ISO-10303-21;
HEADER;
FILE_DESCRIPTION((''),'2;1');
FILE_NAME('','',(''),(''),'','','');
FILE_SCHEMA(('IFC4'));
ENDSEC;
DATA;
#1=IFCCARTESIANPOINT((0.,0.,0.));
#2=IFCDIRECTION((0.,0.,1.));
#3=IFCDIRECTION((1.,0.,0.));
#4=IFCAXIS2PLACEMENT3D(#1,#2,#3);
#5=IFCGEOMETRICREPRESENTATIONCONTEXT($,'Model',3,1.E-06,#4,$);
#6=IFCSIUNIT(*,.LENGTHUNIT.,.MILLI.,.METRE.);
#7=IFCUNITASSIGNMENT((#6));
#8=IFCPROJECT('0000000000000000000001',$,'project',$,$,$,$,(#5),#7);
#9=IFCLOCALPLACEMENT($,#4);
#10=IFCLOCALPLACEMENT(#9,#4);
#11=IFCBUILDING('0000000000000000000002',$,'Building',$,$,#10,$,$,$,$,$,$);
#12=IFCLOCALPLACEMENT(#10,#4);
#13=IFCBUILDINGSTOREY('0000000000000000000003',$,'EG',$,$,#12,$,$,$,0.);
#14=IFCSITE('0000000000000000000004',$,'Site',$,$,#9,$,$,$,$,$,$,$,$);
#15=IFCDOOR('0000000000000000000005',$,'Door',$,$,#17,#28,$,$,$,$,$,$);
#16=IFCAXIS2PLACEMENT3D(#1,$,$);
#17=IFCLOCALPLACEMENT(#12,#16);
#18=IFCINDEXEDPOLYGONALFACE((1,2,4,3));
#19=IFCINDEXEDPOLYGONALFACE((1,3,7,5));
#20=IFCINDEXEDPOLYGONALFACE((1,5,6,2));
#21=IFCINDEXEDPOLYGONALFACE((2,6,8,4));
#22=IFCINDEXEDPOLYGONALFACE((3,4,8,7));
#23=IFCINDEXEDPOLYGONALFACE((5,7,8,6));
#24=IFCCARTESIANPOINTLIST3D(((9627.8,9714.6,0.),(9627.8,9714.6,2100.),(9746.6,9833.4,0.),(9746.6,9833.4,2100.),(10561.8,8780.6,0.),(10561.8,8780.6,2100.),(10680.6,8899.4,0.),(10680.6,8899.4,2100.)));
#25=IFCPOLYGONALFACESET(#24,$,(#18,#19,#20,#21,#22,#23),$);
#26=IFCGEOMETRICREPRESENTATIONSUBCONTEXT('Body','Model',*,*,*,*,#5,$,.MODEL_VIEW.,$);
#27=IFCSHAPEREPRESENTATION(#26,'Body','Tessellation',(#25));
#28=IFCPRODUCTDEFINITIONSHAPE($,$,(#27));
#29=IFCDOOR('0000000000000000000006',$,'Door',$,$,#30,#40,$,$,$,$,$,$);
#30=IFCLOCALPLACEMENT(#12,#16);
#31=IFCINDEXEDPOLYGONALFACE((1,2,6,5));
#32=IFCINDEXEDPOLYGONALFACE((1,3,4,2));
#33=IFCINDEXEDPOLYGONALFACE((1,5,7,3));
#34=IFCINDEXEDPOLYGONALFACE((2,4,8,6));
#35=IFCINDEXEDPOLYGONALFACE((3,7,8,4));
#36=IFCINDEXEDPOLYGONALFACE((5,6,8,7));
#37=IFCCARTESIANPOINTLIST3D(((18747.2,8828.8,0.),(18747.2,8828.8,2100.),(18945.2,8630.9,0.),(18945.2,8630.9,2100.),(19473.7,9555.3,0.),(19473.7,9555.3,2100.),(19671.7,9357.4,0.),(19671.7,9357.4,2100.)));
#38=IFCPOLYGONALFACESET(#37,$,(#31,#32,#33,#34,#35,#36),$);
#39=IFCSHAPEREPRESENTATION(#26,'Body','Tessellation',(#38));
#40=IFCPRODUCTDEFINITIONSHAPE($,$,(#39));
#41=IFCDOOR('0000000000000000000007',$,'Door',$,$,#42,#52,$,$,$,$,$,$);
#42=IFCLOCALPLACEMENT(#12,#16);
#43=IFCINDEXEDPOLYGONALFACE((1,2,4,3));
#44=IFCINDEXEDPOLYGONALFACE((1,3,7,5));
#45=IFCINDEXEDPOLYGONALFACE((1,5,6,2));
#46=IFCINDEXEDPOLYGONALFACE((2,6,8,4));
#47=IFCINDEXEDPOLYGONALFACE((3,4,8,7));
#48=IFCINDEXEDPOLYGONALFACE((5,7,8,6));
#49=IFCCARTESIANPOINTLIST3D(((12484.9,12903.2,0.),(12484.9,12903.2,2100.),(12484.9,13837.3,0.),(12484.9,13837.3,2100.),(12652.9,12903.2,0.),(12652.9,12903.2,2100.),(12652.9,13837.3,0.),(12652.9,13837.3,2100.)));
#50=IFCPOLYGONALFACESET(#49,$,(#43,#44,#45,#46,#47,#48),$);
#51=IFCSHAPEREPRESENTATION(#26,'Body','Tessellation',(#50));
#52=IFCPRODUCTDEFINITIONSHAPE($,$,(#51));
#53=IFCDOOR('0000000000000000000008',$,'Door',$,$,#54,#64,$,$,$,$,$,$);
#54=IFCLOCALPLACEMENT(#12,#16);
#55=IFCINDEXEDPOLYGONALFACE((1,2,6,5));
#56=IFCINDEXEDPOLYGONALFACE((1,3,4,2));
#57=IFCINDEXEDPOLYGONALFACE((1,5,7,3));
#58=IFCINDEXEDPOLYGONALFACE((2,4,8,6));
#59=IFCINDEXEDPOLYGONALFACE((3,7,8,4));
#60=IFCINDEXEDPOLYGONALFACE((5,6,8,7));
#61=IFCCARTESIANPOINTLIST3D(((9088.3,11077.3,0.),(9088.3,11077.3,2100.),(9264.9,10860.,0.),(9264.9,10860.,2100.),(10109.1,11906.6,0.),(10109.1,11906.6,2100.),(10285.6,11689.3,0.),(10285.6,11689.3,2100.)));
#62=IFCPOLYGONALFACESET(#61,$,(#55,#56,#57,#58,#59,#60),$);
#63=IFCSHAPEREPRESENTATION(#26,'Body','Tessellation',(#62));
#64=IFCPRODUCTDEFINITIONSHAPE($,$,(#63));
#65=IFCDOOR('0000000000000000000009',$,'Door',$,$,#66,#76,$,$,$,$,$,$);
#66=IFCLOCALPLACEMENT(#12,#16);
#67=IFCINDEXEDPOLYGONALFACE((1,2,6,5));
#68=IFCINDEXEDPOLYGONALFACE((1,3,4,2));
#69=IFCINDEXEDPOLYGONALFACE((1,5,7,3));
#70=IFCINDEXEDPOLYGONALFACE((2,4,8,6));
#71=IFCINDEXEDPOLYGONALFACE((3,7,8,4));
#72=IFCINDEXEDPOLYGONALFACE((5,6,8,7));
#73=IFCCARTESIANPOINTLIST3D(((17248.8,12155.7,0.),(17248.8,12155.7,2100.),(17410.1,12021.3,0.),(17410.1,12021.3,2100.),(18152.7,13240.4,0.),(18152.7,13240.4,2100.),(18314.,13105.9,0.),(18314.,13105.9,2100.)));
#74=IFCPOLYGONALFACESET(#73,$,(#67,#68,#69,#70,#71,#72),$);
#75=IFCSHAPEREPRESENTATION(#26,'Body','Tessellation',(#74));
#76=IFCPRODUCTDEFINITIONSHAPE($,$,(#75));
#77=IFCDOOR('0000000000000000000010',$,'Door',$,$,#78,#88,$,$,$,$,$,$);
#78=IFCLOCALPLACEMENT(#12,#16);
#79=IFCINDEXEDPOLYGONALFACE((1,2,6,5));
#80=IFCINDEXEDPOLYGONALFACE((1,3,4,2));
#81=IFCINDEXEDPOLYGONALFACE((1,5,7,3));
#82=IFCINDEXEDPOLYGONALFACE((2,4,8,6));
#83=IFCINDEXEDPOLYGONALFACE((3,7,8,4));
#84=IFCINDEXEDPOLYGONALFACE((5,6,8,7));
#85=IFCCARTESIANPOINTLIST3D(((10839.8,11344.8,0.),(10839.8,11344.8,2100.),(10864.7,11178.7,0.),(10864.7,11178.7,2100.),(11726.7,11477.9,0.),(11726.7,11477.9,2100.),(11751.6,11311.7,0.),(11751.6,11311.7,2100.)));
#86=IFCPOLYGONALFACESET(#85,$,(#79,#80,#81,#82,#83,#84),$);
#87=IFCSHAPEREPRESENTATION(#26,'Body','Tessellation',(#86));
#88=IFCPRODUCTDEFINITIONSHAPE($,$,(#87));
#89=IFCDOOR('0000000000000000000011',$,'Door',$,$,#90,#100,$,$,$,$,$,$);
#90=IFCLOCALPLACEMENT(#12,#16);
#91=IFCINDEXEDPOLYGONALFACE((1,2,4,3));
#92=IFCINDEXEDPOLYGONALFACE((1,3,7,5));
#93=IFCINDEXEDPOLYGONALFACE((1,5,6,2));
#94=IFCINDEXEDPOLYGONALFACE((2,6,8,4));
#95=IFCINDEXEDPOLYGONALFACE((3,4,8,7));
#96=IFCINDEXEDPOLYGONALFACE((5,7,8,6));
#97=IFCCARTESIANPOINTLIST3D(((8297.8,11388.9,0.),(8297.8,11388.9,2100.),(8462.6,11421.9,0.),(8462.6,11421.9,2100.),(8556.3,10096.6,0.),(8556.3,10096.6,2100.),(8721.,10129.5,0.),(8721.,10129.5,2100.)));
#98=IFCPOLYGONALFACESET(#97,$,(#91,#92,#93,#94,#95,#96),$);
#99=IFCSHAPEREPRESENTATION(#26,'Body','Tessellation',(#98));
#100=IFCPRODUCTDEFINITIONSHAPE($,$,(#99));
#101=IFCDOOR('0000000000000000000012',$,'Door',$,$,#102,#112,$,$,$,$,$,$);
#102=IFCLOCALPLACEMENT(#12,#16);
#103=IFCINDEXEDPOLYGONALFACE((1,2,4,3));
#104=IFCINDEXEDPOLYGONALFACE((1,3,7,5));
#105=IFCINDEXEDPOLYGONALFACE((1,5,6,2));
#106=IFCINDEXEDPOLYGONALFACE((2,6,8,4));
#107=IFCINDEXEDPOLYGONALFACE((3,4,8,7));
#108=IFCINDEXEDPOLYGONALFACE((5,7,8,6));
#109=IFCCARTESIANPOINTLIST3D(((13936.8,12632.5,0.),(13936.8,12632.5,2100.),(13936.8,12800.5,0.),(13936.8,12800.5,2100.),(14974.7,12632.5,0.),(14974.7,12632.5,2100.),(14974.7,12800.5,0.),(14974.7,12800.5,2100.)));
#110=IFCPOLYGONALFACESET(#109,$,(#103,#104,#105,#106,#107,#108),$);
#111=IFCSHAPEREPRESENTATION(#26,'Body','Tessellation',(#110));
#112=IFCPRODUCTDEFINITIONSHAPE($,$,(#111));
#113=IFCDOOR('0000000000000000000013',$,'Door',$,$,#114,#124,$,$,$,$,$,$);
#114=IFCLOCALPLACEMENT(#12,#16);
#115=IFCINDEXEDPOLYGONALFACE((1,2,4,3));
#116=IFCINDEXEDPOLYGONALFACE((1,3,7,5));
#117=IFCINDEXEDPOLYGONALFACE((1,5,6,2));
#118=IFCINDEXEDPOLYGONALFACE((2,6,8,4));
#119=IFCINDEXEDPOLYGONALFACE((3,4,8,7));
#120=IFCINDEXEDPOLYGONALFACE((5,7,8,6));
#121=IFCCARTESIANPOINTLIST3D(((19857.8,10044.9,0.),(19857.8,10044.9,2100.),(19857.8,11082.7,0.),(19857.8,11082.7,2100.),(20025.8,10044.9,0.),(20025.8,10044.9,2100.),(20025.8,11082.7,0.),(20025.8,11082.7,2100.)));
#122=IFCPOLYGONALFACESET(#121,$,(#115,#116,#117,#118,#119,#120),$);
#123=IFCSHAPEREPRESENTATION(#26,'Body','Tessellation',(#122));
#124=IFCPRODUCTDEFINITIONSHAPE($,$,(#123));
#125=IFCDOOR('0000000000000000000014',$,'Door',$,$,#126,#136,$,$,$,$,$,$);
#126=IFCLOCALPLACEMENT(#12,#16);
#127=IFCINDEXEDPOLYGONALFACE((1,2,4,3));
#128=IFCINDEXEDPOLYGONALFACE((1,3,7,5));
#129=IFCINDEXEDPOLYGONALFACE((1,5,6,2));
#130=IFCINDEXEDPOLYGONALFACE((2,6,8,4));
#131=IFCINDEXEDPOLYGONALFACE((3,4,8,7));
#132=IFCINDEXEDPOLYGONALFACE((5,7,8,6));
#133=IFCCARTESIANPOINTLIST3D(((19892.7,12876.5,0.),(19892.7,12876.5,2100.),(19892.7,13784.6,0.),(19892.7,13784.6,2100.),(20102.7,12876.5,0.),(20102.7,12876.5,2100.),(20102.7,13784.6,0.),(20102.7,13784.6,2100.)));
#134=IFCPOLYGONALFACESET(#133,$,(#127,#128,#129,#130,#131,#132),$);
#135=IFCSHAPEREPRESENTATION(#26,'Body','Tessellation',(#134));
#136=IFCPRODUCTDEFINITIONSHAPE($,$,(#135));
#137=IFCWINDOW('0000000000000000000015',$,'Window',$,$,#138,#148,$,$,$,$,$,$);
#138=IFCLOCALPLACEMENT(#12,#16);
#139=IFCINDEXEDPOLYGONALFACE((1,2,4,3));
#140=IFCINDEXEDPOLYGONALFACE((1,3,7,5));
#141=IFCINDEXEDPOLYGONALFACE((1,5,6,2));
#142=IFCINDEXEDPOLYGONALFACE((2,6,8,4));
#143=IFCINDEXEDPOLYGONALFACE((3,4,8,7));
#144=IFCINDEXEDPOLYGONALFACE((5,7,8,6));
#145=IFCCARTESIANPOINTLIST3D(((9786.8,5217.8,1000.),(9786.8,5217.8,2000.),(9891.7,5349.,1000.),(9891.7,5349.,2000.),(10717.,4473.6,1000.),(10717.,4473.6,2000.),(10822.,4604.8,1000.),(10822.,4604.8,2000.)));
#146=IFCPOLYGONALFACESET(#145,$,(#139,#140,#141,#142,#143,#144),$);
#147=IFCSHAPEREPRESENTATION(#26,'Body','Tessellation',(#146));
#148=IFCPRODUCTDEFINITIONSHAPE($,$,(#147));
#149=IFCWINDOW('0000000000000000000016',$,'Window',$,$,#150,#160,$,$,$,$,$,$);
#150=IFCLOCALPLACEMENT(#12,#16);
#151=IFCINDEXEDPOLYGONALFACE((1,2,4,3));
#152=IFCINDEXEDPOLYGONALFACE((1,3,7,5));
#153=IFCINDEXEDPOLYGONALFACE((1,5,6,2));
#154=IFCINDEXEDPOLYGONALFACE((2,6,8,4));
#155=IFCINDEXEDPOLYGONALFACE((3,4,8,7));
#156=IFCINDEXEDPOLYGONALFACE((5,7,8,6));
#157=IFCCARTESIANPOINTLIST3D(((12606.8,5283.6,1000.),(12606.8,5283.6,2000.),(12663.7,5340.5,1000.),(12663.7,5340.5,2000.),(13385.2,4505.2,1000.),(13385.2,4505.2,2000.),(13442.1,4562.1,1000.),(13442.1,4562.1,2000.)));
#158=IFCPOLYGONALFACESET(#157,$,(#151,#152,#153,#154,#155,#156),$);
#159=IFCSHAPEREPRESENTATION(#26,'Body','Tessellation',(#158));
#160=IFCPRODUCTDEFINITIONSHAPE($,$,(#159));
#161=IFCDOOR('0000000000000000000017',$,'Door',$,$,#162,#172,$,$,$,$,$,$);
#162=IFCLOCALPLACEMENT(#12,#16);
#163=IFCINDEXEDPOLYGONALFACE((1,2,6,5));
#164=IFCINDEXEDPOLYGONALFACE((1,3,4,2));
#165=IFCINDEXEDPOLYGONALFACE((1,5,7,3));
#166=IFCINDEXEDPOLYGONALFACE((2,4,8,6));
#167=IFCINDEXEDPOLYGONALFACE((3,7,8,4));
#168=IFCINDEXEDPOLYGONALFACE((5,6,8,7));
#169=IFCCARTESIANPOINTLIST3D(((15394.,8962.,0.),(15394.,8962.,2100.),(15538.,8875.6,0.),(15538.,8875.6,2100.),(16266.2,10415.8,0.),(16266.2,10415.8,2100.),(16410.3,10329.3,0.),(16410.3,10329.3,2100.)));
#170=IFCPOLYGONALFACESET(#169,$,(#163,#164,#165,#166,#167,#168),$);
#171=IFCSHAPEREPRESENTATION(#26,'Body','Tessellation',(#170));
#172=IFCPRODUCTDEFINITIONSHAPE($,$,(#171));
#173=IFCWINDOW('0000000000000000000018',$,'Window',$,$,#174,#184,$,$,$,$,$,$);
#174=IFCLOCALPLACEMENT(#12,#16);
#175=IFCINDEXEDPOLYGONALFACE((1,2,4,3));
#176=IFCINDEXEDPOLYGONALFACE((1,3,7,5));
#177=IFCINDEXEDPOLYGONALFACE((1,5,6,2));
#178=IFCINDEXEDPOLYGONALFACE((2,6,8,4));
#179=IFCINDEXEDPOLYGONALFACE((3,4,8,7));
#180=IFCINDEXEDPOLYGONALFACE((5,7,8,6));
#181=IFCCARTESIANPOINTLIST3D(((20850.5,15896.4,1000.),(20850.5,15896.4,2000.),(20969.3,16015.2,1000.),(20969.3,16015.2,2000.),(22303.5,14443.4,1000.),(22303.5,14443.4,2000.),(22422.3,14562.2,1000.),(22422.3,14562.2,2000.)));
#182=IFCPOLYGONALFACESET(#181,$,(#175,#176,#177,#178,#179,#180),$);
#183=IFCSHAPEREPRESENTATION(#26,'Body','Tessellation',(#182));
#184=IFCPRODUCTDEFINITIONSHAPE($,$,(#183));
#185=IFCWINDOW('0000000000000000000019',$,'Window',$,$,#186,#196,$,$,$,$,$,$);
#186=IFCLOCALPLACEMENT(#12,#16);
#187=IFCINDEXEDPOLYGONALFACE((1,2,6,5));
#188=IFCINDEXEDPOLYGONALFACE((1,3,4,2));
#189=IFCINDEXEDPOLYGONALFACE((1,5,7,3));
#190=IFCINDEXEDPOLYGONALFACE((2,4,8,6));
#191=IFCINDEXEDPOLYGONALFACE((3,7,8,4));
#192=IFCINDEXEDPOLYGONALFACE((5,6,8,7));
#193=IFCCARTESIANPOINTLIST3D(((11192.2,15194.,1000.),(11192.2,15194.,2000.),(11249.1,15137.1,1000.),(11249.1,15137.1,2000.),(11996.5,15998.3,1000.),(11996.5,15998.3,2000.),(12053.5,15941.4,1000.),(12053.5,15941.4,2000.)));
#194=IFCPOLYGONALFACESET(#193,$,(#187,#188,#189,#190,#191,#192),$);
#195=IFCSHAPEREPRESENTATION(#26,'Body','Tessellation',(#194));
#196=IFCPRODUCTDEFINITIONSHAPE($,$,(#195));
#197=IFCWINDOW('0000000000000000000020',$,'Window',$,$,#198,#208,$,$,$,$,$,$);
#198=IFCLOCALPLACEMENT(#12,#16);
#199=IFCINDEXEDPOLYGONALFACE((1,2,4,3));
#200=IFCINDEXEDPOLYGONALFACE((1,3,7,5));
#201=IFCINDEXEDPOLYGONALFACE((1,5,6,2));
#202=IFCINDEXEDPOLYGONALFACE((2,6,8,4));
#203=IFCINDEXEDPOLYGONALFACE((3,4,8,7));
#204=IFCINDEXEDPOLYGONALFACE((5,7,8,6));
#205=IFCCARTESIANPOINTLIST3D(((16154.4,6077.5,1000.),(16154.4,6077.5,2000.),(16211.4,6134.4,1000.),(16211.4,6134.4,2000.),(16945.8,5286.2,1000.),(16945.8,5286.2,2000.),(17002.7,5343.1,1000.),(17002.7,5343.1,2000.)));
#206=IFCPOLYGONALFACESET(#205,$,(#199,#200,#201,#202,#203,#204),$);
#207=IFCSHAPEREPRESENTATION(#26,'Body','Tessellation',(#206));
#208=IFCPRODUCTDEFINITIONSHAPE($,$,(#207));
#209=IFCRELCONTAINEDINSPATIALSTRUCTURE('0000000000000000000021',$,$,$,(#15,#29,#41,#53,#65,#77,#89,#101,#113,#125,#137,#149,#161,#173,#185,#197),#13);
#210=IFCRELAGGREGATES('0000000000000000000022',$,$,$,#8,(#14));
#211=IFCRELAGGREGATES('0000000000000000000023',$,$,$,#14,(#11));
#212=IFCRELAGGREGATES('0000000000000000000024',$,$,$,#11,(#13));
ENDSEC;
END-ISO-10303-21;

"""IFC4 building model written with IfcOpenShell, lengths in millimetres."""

from ifc_helpers import new_model, si_unit, frame, origin_with_axes, place, context, subcontext, project, spatial, rectangle, extrude, element, save


model = new_model("IFC4")

# Units and contexts
model_context = context("Model", 3, precision=1e-06, world=origin_with_axes())
body_context = subcontext(model_context, "Body", "Model", "MODEL_VIEW")
ifc_project = project(units=[si_unit("LENGTHUNIT", "METRE", prefix="MILLI")], contexts=[model_context])

# Site, building, storey
site_placement = place(None, origin_with_axes())
site = spatial("IfcSite", under=ifc_project, at=site_placement, Name="Site")
building_placement = place(site_placement, origin_with_axes())
building = spatial("IfcBuilding", under=site, at=building_placement, Name="Building")
storey_placement = place(building_placement, origin_with_axes())
storey = spatial("IfcBuildingStorey", under=building, at=storey_placement, Name="EG", Elevation=0.0)

# Doors
door_1_placement = place(storey_placement, origin_with_axes())
element("IfcDoor", 1, at=door_1_placement, inside=storey, Name="Door", context=body_context, shape_type="SweptSolid", body=[
    extrude(rectangle(XDim=1321.0, YDim=168.0), frame((10154.2, 9307.0, 0.0), z_axis=(0.0, 0.0, 1.0), x_axis=(0.707107, -0.707107, 0.0)), (0.0, 0.0, 1.0), 2100.0),
])
door_2_placement = place(storey_placement, origin_with_axes())
element("IfcDoor", 2, at=door_2_placement, inside=storey, Name="Door", context=body_context, shape_type="SweptSolid", body=[
    extrude(rectangle(XDim=1027.4, YDim=280.0), frame((19209.4, 9093.1, 0.0), z_axis=(0.0, 0.0, 1.0), x_axis=(-0.707107, -0.707107, 0.0)), (0.0, 0.0, 1.0), 2100.0),
])
door_3_placement = place(storey_placement, origin_with_axes())
element("IfcDoor", 3, at=door_3_placement, inside=storey, Name="Door", context=body_context, shape_type="SweptSolid", body=[
    extrude(rectangle(XDim=934.1, YDim=168.0), frame((12568.9, 13370.2, 0.0), z_axis=(0.0, 0.0, 1.0), x_axis=(0.0, -1.0, 0.0)), (0.0, 0.0, 1.0), 2100.0),
])
door_4_placement = place(storey_placement, origin_with_axes())
element("IfcDoor", 4, at=door_4_placement, inside=storey, Name="Door", context=body_context, shape_type="SweptSolid", body=[
    extrude(rectangle(XDim=1315.2, YDim=280.0), frame((9687.0, 11383.3, 0.0), z_axis=(0.0, 0.0, 1.0), x_axis=(-0.776114, -0.630593, 0.0)), (0.0, 0.0, 1.0), 2100.0),
])
door_5_placement = place(storey_placement, origin_with_axes())
element("IfcDoor", 5, at=door_5_placement, inside=storey, Name="Door", context=body_context, shape_type="SweptSolid", body=[
    extrude(rectangle(XDim=1411.9, YDim=210.0), frame((17781.4, 12630.8, 0.0), z_axis=(0.0, 0.0, 1.0), x_axis=(-0.640184, -0.768221, 0.0)), (0.0, 0.0, 1.0), 2100.0),
])
door_6_placement = place(storey_placement, origin_with_axes())
element("IfcDoor", 6, at=door_6_placement, inside=storey, Name="Door", context=body_context, shape_type="SweptSolid", body=[
    extrude(rectangle(XDim=896.8, YDim=168.0), frame((11295.7, 11328.3, 0.0), z_axis=(0.0, 0.0, 1.0), x_axis=(-0.988936, -0.14834, 0.0)), (0.0, 0.0, 1.0), 2100.0),
])
door_7_placement = place(storey_placement, origin_with_axes())
element("IfcDoor", 7, at=door_7_placement, inside=storey, Name="Door", context=body_context, shape_type="SweptSolid", body=[
    extrude(rectangle(XDim=1317.9, YDim=168.0), frame((8509.4, 10759.2, 0.0), z_axis=(0.0, 0.0, 1.0), x_axis=(-0.196116, 0.980581, 0.0)), (0.0, 0.0, 1.0), 2100.0),
])
door_8_placement = place(storey_placement, origin_with_axes())
element("IfcDoor", 8, at=door_8_placement, inside=storey, Name="Door", context=body_context, shape_type="SweptSolid", body=[
    extrude(rectangle(XDim=1037.8, YDim=168.0), frame((14455.7, 12716.5, 0.0), z_axis=(0.0, 0.0, 1.0), x_axis=(1.0, 0.0, 0.0)), (0.0, 0.0, 1.0), 2100.0),
])
door_9_placement = place(storey_placement, origin_with_axes())
element("IfcDoor", 9, at=door_9_placement, inside=storey, Name="Door", context=body_context, shape_type="SweptSolid", body=[
    extrude(rectangle(XDim=1037.8, YDim=168.0), frame((19941.8, 10563.8, 0.0), z_axis=(0.0, 0.0, 1.0), x_axis=(0.0, -1.0, 0.0)), (0.0, 0.0, 1.0), 2100.0),
])
door_10_placement = place(storey_placement, origin_with_axes())
element("IfcDoor", 10, at=door_10_placement, inside=storey, Name="Door", context=body_context, shape_type="SweptSolid", body=[
    extrude(rectangle(XDim=908.1, YDim=210.0), frame((19997.7, 13330.5, 0.0), z_axis=(0.0, 0.0, 1.0), x_axis=(0.0, -1.0, 0.0)), (0.0, 0.0, 1.0), 2100.0),
])

# Windows
window_1_placement = place(storey_placement, origin_with_axes())
element("IfcWindow", 11, at=window_1_placement, inside=storey, Name="Window", context=body_context, shape_type="SweptSolid", body=[
    extrude(rectangle(XDim=1191.3, YDim=168.0), frame((10304.4, 4911.3, 1000.0), z_axis=(0.0, 0.0, 1.0), x_axis=(0.780869, -0.624695, 0.0)), (0.0, 0.0, 1.0), 1000.0),
])
window_2_placement = place(storey_placement, origin_with_axes())
element("IfcWindow", 12, at=window_2_placement, inside=storey, Name="Window", context=body_context, shape_type="SweptSolid", body=[
    extrude(rectangle(XDim=1100.8, YDim=80.5), frame((13024.4, 4922.9, 1000.0), z_axis=(0.0, 0.0, 1.0), x_axis=(0.707107, -0.707107, 0.0)), (0.0, 0.0, 1.0), 1000.0),
])

# Door
door_11_placement = place(storey_placement, origin_with_axes())
element("IfcDoor", 13, at=door_11_placement, inside=storey, Name="Door", context=body_context, shape_type="SweptSolid", body=[
    extrude(rectangle(XDim=1695.3, YDim=168.0), frame((15902.1, 9645.7, 0.0), z_axis=(0.0, 0.0, 1.0), x_axis=(0.514496, 0.857493, 0.0)), (0.0, 0.0, 1.0), 2100.0),
])

# Windows
window_3_placement = place(storey_placement, origin_with_axes())
element("IfcWindow", 14, at=window_3_placement, inside=storey, Name="Window", context=body_context, shape_type="SweptSolid", body=[
    extrude(rectangle(XDim=2054.8, YDim=168.0), frame((21636.4, 15229.3, 1000.0), z_axis=(0.0, 0.0, 1.0), x_axis=(0.707107, -0.707107, 0.0)), (0.0, 0.0, 1.0), 1000.0),
])
window_4_placement = place(storey_placement, origin_with_axes())
element("IfcWindow", 15, at=window_4_placement, inside=storey, Name="Window", context=body_context, shape_type="SweptSolid", body=[
    extrude(rectangle(XDim=1137.5, YDim=80.5), frame((11622.8, 15567.7, 1000.0), z_axis=(0.0, 0.0, 1.0), x_axis=(-0.707107, -0.707107, 0.0)), (0.0, 0.0, 1.0), 1000.0),
])
window_5_placement = place(storey_placement, origin_with_axes())
element("IfcWindow", 16, at=window_5_placement, inside=storey, Name="Window", context=body_context, shape_type="SweptSolid", body=[
    extrude(rectangle(XDim=1119.1, YDim=80.5), frame((16578.6, 5710.3, 1000.0), z_axis=(0.0, 0.0, 1.0), x_axis=(-0.707107, 0.707107, 0.0)), (0.0, 0.0, 1.0), 1000.0),
])

save(model, "model.ifc")
